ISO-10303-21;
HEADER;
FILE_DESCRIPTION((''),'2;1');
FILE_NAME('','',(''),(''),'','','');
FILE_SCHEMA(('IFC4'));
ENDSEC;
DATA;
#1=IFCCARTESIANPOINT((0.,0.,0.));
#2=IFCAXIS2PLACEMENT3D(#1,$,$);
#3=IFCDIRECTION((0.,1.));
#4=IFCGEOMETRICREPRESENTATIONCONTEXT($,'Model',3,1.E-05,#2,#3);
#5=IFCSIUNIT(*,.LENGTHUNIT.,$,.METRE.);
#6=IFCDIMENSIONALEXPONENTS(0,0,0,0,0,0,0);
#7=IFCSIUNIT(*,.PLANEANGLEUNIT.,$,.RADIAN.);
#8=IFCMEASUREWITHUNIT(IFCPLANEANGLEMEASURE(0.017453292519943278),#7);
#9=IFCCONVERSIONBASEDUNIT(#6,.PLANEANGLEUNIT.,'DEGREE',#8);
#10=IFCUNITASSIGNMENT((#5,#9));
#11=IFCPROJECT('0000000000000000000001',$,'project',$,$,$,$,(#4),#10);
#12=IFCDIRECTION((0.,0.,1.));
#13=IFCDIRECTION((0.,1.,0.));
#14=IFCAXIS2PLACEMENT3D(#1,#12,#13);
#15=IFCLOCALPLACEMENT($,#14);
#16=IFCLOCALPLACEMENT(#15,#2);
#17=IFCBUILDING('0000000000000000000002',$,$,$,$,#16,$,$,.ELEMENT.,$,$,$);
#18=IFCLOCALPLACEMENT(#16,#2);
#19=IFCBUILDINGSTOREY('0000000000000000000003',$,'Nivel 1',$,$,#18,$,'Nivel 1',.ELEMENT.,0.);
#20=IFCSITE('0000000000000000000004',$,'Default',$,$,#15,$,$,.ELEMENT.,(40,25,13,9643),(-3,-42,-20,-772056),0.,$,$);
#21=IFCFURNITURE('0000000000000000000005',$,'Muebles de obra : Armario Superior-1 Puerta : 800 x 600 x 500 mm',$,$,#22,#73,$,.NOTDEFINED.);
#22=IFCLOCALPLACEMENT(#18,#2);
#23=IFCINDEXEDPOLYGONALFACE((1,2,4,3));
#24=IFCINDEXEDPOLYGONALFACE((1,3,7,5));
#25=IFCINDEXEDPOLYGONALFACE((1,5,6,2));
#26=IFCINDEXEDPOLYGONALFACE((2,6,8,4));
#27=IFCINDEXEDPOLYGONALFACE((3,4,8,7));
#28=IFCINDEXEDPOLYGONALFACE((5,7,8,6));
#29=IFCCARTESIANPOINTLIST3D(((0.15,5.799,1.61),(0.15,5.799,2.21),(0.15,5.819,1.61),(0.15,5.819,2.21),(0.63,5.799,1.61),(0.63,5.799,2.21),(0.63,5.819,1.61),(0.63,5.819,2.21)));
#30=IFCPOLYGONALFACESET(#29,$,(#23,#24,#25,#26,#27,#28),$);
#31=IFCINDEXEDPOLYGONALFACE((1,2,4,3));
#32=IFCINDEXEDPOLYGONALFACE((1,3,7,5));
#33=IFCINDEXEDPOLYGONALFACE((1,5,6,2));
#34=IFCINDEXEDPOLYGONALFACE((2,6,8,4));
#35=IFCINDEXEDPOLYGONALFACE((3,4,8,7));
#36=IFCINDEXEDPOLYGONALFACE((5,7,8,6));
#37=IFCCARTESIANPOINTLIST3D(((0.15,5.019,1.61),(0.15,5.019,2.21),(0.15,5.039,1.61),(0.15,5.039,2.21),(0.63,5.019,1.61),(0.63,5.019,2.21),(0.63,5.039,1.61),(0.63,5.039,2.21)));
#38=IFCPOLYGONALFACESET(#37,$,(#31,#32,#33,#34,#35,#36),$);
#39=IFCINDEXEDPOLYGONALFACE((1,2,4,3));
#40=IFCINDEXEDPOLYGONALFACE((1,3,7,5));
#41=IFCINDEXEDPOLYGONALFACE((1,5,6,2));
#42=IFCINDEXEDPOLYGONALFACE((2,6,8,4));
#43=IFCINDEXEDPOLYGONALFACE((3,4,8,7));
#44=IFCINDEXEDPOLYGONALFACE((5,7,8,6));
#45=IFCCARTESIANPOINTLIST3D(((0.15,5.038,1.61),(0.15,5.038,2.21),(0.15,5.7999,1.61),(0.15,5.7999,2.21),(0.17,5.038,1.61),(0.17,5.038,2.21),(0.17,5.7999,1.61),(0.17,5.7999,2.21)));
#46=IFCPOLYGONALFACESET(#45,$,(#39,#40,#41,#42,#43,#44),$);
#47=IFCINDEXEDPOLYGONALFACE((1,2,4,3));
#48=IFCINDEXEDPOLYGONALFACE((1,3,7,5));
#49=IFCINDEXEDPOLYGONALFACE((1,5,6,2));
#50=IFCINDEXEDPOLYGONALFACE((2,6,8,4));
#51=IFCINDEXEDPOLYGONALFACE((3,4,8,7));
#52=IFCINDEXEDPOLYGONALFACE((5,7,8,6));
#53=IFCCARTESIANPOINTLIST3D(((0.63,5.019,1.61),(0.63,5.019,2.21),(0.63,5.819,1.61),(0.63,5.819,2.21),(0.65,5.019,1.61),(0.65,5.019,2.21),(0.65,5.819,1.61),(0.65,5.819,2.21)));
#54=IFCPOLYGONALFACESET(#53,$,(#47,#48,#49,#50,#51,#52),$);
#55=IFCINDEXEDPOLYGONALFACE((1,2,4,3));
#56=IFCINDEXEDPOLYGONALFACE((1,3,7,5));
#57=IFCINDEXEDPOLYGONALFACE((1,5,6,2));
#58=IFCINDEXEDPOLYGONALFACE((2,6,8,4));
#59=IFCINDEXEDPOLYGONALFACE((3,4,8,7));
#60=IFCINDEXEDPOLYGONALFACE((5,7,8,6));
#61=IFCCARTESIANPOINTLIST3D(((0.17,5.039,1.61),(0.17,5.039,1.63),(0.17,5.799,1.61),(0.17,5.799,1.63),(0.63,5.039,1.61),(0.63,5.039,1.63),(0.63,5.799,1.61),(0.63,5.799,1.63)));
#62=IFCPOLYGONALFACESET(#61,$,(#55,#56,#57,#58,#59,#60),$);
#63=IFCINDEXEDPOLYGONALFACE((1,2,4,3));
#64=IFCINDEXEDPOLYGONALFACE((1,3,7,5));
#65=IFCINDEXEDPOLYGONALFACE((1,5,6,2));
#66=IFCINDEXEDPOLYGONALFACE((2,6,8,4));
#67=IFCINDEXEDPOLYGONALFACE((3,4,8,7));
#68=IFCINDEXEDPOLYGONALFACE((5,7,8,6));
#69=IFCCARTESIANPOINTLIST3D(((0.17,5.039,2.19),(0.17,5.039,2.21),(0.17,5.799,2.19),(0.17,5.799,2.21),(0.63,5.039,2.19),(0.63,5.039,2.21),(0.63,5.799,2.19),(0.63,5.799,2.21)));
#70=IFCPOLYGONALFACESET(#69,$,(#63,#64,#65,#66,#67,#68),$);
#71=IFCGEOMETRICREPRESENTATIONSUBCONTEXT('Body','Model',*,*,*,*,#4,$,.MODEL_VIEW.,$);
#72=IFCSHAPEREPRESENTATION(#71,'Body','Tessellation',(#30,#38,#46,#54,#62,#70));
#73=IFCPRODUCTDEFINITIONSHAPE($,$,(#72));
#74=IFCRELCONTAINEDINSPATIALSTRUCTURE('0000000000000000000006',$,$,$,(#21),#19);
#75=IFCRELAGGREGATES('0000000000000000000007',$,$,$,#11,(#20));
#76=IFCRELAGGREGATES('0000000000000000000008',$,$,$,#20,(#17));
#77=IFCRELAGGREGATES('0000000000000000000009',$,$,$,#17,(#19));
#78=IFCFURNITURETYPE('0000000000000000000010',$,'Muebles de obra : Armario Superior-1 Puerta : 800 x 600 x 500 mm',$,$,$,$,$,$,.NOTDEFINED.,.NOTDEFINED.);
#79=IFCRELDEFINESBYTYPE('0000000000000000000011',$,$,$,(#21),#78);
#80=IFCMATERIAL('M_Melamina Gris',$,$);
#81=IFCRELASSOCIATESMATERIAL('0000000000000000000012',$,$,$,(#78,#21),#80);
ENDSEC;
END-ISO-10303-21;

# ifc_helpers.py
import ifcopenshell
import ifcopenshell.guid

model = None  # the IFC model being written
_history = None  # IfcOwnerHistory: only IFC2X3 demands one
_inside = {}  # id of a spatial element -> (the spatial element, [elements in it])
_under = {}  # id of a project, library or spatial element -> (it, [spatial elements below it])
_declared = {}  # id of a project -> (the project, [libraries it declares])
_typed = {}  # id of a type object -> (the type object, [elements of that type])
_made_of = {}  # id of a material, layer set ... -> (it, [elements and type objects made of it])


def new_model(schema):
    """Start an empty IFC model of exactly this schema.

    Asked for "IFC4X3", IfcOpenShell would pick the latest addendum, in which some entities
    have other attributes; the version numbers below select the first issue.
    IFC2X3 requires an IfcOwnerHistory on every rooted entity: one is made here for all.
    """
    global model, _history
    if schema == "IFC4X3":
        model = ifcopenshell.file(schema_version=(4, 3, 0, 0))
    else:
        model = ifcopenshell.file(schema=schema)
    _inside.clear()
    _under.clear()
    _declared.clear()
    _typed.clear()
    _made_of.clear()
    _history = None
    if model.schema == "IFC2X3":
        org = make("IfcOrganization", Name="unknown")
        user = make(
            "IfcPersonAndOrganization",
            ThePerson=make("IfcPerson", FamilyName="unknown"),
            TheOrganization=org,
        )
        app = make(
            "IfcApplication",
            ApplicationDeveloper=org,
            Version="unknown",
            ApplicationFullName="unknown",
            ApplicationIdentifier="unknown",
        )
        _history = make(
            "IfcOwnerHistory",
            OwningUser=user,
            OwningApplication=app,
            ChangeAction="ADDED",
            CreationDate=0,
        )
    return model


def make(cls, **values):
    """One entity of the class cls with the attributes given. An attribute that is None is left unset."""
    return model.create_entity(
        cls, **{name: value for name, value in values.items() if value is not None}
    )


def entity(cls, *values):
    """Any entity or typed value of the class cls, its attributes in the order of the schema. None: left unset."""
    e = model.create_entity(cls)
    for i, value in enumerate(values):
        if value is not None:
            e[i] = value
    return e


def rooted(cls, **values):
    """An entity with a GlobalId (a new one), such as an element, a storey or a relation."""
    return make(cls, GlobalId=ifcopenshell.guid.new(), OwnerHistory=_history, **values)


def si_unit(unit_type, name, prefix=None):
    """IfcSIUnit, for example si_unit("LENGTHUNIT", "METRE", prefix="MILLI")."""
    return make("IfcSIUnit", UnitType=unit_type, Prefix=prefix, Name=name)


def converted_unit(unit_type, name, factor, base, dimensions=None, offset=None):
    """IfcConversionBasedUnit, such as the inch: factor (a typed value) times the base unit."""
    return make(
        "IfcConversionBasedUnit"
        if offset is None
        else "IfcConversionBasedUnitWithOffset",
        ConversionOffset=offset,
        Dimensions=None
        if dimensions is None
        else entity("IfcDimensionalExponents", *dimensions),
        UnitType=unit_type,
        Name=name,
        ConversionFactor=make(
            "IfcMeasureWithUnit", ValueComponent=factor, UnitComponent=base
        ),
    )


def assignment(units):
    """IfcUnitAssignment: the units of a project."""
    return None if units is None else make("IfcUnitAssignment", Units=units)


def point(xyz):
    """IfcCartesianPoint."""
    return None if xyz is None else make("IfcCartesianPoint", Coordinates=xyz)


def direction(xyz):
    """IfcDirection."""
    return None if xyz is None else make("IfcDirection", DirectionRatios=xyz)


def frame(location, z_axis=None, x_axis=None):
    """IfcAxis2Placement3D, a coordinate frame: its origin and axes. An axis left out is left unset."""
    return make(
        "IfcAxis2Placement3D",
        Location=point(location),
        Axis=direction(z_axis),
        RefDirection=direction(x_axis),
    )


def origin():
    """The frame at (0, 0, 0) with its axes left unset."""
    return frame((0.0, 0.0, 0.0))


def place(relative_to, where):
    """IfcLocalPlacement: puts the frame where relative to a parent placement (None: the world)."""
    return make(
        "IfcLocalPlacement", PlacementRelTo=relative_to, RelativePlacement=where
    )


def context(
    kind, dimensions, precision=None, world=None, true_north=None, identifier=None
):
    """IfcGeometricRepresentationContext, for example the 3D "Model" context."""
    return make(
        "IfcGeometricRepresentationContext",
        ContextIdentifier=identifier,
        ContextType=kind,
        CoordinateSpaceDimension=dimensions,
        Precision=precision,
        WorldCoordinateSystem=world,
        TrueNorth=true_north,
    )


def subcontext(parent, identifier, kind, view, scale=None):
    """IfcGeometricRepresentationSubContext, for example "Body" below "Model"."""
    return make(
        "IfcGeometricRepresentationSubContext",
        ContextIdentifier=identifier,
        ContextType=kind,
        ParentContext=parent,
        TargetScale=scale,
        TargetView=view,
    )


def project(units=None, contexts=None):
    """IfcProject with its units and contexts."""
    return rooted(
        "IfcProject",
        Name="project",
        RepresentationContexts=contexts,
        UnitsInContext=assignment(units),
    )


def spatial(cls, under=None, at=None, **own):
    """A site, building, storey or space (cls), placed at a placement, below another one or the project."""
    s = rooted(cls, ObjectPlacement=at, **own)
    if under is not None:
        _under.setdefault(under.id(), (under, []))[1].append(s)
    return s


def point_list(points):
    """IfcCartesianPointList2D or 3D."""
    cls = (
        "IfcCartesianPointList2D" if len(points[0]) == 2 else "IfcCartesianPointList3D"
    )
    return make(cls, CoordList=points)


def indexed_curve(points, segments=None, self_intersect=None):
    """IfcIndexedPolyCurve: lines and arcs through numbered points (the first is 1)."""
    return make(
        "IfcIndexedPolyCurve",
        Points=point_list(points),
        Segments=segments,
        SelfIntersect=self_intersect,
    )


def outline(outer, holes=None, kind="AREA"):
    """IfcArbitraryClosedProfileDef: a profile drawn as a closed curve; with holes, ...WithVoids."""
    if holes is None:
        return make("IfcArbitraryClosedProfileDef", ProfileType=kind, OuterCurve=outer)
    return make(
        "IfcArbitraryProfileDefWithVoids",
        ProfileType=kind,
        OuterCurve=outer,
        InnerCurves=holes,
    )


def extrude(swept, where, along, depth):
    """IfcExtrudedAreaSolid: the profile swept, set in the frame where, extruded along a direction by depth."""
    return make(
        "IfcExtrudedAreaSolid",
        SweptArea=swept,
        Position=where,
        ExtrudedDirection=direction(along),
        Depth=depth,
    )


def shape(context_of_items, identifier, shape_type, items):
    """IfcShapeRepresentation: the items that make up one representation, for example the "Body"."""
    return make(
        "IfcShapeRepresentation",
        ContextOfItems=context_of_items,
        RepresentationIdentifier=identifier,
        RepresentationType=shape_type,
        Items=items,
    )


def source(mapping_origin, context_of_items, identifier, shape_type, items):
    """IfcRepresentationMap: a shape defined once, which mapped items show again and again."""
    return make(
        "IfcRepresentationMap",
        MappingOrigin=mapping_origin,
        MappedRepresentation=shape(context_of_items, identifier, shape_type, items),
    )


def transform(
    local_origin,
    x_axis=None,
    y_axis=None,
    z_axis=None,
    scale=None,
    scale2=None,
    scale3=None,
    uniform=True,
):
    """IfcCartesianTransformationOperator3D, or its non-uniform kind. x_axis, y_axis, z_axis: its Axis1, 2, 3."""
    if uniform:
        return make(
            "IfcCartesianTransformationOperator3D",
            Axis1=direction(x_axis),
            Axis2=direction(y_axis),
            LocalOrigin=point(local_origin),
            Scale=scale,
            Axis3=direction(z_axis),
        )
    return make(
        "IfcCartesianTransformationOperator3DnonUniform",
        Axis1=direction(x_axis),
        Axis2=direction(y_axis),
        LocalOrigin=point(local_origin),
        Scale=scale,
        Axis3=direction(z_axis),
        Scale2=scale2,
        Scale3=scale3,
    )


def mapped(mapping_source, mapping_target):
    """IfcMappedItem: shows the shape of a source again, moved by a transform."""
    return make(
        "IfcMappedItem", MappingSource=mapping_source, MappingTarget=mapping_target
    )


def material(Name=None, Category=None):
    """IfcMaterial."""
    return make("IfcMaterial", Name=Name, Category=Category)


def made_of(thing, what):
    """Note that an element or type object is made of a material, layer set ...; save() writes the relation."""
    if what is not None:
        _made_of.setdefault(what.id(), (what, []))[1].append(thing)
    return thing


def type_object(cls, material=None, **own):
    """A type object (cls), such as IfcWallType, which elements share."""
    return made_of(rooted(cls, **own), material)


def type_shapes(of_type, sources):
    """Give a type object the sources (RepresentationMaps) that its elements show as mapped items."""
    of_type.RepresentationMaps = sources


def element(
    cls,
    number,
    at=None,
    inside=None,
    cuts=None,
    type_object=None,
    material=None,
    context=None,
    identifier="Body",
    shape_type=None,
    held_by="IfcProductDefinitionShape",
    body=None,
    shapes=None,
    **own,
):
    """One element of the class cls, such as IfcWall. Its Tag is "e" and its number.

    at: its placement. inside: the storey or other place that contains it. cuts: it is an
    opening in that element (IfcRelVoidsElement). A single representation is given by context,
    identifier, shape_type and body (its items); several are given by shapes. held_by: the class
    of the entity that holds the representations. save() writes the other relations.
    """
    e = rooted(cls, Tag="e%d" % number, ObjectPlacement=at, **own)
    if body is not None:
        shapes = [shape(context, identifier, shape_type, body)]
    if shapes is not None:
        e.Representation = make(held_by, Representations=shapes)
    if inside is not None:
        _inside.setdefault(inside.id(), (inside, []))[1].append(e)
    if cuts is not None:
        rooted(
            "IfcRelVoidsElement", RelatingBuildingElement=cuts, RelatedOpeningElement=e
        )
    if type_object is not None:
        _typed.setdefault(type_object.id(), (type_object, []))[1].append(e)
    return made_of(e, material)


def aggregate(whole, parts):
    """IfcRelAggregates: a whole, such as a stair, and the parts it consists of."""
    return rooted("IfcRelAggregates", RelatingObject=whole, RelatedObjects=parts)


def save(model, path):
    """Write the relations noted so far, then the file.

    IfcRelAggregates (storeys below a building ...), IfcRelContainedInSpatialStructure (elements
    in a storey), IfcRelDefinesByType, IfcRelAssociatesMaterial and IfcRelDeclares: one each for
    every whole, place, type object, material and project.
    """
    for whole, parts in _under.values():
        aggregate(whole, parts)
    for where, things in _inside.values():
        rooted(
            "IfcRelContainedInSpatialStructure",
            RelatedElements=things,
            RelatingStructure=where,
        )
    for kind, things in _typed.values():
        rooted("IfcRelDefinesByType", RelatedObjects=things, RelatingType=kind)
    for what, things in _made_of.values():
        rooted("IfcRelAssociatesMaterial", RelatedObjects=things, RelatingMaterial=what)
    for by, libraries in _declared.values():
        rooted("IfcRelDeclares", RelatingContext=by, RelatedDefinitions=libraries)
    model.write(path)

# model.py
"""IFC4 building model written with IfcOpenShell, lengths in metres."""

from ifc_helpers import new_model, entity, si_unit, converted_unit, direction, frame, origin, place, context, subcontext, project, spatial, indexed_curve, outline, extrude, source, transform, mapped, material, type_object, type_shapes, element, save


model = new_model("IFC4")

# Units and contexts
model_context = context("Model", 3, precision=1e-05, world=origin(), true_north=direction((0.0, 1.0)))
body_context = subcontext(model_context, "Body", "Model", "MODEL_VIEW")
ifc_project = project(units=[si_unit("LENGTHUNIT", "METRE"), converted_unit("PLANEANGLEUNIT", "DEGREE", entity("IfcPlaneAngleMeasure", 0.017453292519943278), si_unit("PLANEANGLEUNIT", "RADIAN"), dimensions=[0, 0, 0, 0, 0, 0, 0])], contexts=[model_context])

# Site, building, storey
site_placement = place(None, frame((0.0, 0.0, 0.0), z_axis=(0.0, 0.0, 1.0), x_axis=(0.0, 1.0, 0.0)))
site = spatial("IfcSite", under=ifc_project, at=site_placement, Name="Default", CompositionType="ELEMENT", RefLatitude=(40, 25, 13, 9643), RefLongitude=(-3, -42, -20, -772056), RefElevation=0.0)
building_placement = place(site_placement, origin())
building = spatial("IfcBuilding", under=site, at=building_placement, CompositionType="ELEMENT")
storey_placement = place(building_placement, origin())
storey = spatial("IfcBuildingStorey", under=building, at=storey_placement, Name="Nivel 1", LongName="Nivel 1", CompositionType="ELEMENT", Elevation=0.0)

# Furniture
ifc_material_1 = material(Name="M_Melamina Gris")
furniture_type_1 = type_object("IfcFurnitureType", Name="Muebles de obra : Armario Superior-1 Puerta : 800 x 600 x 500 mm", AssemblyPlace="NOTDEFINED", PredefinedType="NOTDEFINED", material=ifc_material_1)
shared_shape_1 = source(origin(), body_context, "Body", "SweptSolid", [
    extrude(outline(indexed_curve([(-0.01, -0.24), (0.01, -0.24), (0.01, 0.24), (-0.01, 0.24), (-0.01, -0.24)], self_intersect=False)), frame((-0.4213, 0.24, 0.0), z_axis=(0.0, 0.0, 1.0), x_axis=(-1.0, 0.0, 0.0)), (0.0, 0.0, 1.0), 0.6),
    extrude(outline(indexed_curve([(-0.24, -0.01), (0.24, -0.01), (0.24, 0.01), (-0.24, 0.01), (-0.24, -0.01)], self_intersect=False)), frame((0.3587, 0.24, 0.0), z_axis=(0.0, 0.0, 1.0), x_axis=(0.0, -1.0, 0.0)), (0.0, 0.0, 1.0), 0.6),
    extrude(outline(indexed_curve([(-0.381, -0.01), (0.381, -0.01), (0.381, 0.01), (-0.381, 0.01), (-0.381, -0.01)], self_intersect=False)), frame((-0.0313, 0.01, 0.0)), (0.0, 0.0, 1.0), 0.6),
    extrude(outline(indexed_curve([(-0.4, -0.01), (0.4, -0.01), (0.4, 0.01), (-0.4, 0.01), (-0.4, -0.01)], self_intersect=False)), frame((-0.0313, 0.49, 0.0)), (0.0, 0.0, 1.0), 0.6),
    extrude(outline(indexed_curve([(-0.23, -0.38), (0.23, -0.38), (0.23, 0.38), (-0.23, 0.38), (-0.23, -0.38)], self_intersect=False)), frame((-0.0313, 0.25, 0.0), z_axis=(0.0, 0.0, 1.0), x_axis=(0.0, 1.0, 0.0)), (0.0, 0.0, 1.0), 0.02),
    extrude(outline(indexed_curve([(-0.23, -0.38), (0.23, -0.38), (0.23, 0.38), (-0.23, 0.38), (-0.23, -0.38)], self_intersect=False)), frame((-0.0313, 0.25, 0.58), z_axis=(0.0, 0.0, 1.0), x_axis=(0.0, 1.0, 0.0)), (0.0, 0.0, 1.0), 0.02),
])
type_shapes(furniture_type_1, [shared_shape_1])
furniture_1_placement = place(storey_placement, frame((0.15, 5.3877, 1.61), z_axis=(0.0, 0.0, 1.0), x_axis=(0.0, -1.0, 0.0)))
element("IfcFurniture", 1, at=furniture_1_placement, inside=storey, type_object=furniture_type_1, material=ifc_material_1, Name="Muebles de obra : Armario Superior-1 Puerta : 800 x 600 x 500 mm", PredefinedType="NOTDEFINED", context=body_context, shape_type="MappedRepresentation", body=[
    mapped(shared_shape_1, transform((0.0, 0.0, 0.0), scale=1.0)),
])

save(model, "model.ifc")
